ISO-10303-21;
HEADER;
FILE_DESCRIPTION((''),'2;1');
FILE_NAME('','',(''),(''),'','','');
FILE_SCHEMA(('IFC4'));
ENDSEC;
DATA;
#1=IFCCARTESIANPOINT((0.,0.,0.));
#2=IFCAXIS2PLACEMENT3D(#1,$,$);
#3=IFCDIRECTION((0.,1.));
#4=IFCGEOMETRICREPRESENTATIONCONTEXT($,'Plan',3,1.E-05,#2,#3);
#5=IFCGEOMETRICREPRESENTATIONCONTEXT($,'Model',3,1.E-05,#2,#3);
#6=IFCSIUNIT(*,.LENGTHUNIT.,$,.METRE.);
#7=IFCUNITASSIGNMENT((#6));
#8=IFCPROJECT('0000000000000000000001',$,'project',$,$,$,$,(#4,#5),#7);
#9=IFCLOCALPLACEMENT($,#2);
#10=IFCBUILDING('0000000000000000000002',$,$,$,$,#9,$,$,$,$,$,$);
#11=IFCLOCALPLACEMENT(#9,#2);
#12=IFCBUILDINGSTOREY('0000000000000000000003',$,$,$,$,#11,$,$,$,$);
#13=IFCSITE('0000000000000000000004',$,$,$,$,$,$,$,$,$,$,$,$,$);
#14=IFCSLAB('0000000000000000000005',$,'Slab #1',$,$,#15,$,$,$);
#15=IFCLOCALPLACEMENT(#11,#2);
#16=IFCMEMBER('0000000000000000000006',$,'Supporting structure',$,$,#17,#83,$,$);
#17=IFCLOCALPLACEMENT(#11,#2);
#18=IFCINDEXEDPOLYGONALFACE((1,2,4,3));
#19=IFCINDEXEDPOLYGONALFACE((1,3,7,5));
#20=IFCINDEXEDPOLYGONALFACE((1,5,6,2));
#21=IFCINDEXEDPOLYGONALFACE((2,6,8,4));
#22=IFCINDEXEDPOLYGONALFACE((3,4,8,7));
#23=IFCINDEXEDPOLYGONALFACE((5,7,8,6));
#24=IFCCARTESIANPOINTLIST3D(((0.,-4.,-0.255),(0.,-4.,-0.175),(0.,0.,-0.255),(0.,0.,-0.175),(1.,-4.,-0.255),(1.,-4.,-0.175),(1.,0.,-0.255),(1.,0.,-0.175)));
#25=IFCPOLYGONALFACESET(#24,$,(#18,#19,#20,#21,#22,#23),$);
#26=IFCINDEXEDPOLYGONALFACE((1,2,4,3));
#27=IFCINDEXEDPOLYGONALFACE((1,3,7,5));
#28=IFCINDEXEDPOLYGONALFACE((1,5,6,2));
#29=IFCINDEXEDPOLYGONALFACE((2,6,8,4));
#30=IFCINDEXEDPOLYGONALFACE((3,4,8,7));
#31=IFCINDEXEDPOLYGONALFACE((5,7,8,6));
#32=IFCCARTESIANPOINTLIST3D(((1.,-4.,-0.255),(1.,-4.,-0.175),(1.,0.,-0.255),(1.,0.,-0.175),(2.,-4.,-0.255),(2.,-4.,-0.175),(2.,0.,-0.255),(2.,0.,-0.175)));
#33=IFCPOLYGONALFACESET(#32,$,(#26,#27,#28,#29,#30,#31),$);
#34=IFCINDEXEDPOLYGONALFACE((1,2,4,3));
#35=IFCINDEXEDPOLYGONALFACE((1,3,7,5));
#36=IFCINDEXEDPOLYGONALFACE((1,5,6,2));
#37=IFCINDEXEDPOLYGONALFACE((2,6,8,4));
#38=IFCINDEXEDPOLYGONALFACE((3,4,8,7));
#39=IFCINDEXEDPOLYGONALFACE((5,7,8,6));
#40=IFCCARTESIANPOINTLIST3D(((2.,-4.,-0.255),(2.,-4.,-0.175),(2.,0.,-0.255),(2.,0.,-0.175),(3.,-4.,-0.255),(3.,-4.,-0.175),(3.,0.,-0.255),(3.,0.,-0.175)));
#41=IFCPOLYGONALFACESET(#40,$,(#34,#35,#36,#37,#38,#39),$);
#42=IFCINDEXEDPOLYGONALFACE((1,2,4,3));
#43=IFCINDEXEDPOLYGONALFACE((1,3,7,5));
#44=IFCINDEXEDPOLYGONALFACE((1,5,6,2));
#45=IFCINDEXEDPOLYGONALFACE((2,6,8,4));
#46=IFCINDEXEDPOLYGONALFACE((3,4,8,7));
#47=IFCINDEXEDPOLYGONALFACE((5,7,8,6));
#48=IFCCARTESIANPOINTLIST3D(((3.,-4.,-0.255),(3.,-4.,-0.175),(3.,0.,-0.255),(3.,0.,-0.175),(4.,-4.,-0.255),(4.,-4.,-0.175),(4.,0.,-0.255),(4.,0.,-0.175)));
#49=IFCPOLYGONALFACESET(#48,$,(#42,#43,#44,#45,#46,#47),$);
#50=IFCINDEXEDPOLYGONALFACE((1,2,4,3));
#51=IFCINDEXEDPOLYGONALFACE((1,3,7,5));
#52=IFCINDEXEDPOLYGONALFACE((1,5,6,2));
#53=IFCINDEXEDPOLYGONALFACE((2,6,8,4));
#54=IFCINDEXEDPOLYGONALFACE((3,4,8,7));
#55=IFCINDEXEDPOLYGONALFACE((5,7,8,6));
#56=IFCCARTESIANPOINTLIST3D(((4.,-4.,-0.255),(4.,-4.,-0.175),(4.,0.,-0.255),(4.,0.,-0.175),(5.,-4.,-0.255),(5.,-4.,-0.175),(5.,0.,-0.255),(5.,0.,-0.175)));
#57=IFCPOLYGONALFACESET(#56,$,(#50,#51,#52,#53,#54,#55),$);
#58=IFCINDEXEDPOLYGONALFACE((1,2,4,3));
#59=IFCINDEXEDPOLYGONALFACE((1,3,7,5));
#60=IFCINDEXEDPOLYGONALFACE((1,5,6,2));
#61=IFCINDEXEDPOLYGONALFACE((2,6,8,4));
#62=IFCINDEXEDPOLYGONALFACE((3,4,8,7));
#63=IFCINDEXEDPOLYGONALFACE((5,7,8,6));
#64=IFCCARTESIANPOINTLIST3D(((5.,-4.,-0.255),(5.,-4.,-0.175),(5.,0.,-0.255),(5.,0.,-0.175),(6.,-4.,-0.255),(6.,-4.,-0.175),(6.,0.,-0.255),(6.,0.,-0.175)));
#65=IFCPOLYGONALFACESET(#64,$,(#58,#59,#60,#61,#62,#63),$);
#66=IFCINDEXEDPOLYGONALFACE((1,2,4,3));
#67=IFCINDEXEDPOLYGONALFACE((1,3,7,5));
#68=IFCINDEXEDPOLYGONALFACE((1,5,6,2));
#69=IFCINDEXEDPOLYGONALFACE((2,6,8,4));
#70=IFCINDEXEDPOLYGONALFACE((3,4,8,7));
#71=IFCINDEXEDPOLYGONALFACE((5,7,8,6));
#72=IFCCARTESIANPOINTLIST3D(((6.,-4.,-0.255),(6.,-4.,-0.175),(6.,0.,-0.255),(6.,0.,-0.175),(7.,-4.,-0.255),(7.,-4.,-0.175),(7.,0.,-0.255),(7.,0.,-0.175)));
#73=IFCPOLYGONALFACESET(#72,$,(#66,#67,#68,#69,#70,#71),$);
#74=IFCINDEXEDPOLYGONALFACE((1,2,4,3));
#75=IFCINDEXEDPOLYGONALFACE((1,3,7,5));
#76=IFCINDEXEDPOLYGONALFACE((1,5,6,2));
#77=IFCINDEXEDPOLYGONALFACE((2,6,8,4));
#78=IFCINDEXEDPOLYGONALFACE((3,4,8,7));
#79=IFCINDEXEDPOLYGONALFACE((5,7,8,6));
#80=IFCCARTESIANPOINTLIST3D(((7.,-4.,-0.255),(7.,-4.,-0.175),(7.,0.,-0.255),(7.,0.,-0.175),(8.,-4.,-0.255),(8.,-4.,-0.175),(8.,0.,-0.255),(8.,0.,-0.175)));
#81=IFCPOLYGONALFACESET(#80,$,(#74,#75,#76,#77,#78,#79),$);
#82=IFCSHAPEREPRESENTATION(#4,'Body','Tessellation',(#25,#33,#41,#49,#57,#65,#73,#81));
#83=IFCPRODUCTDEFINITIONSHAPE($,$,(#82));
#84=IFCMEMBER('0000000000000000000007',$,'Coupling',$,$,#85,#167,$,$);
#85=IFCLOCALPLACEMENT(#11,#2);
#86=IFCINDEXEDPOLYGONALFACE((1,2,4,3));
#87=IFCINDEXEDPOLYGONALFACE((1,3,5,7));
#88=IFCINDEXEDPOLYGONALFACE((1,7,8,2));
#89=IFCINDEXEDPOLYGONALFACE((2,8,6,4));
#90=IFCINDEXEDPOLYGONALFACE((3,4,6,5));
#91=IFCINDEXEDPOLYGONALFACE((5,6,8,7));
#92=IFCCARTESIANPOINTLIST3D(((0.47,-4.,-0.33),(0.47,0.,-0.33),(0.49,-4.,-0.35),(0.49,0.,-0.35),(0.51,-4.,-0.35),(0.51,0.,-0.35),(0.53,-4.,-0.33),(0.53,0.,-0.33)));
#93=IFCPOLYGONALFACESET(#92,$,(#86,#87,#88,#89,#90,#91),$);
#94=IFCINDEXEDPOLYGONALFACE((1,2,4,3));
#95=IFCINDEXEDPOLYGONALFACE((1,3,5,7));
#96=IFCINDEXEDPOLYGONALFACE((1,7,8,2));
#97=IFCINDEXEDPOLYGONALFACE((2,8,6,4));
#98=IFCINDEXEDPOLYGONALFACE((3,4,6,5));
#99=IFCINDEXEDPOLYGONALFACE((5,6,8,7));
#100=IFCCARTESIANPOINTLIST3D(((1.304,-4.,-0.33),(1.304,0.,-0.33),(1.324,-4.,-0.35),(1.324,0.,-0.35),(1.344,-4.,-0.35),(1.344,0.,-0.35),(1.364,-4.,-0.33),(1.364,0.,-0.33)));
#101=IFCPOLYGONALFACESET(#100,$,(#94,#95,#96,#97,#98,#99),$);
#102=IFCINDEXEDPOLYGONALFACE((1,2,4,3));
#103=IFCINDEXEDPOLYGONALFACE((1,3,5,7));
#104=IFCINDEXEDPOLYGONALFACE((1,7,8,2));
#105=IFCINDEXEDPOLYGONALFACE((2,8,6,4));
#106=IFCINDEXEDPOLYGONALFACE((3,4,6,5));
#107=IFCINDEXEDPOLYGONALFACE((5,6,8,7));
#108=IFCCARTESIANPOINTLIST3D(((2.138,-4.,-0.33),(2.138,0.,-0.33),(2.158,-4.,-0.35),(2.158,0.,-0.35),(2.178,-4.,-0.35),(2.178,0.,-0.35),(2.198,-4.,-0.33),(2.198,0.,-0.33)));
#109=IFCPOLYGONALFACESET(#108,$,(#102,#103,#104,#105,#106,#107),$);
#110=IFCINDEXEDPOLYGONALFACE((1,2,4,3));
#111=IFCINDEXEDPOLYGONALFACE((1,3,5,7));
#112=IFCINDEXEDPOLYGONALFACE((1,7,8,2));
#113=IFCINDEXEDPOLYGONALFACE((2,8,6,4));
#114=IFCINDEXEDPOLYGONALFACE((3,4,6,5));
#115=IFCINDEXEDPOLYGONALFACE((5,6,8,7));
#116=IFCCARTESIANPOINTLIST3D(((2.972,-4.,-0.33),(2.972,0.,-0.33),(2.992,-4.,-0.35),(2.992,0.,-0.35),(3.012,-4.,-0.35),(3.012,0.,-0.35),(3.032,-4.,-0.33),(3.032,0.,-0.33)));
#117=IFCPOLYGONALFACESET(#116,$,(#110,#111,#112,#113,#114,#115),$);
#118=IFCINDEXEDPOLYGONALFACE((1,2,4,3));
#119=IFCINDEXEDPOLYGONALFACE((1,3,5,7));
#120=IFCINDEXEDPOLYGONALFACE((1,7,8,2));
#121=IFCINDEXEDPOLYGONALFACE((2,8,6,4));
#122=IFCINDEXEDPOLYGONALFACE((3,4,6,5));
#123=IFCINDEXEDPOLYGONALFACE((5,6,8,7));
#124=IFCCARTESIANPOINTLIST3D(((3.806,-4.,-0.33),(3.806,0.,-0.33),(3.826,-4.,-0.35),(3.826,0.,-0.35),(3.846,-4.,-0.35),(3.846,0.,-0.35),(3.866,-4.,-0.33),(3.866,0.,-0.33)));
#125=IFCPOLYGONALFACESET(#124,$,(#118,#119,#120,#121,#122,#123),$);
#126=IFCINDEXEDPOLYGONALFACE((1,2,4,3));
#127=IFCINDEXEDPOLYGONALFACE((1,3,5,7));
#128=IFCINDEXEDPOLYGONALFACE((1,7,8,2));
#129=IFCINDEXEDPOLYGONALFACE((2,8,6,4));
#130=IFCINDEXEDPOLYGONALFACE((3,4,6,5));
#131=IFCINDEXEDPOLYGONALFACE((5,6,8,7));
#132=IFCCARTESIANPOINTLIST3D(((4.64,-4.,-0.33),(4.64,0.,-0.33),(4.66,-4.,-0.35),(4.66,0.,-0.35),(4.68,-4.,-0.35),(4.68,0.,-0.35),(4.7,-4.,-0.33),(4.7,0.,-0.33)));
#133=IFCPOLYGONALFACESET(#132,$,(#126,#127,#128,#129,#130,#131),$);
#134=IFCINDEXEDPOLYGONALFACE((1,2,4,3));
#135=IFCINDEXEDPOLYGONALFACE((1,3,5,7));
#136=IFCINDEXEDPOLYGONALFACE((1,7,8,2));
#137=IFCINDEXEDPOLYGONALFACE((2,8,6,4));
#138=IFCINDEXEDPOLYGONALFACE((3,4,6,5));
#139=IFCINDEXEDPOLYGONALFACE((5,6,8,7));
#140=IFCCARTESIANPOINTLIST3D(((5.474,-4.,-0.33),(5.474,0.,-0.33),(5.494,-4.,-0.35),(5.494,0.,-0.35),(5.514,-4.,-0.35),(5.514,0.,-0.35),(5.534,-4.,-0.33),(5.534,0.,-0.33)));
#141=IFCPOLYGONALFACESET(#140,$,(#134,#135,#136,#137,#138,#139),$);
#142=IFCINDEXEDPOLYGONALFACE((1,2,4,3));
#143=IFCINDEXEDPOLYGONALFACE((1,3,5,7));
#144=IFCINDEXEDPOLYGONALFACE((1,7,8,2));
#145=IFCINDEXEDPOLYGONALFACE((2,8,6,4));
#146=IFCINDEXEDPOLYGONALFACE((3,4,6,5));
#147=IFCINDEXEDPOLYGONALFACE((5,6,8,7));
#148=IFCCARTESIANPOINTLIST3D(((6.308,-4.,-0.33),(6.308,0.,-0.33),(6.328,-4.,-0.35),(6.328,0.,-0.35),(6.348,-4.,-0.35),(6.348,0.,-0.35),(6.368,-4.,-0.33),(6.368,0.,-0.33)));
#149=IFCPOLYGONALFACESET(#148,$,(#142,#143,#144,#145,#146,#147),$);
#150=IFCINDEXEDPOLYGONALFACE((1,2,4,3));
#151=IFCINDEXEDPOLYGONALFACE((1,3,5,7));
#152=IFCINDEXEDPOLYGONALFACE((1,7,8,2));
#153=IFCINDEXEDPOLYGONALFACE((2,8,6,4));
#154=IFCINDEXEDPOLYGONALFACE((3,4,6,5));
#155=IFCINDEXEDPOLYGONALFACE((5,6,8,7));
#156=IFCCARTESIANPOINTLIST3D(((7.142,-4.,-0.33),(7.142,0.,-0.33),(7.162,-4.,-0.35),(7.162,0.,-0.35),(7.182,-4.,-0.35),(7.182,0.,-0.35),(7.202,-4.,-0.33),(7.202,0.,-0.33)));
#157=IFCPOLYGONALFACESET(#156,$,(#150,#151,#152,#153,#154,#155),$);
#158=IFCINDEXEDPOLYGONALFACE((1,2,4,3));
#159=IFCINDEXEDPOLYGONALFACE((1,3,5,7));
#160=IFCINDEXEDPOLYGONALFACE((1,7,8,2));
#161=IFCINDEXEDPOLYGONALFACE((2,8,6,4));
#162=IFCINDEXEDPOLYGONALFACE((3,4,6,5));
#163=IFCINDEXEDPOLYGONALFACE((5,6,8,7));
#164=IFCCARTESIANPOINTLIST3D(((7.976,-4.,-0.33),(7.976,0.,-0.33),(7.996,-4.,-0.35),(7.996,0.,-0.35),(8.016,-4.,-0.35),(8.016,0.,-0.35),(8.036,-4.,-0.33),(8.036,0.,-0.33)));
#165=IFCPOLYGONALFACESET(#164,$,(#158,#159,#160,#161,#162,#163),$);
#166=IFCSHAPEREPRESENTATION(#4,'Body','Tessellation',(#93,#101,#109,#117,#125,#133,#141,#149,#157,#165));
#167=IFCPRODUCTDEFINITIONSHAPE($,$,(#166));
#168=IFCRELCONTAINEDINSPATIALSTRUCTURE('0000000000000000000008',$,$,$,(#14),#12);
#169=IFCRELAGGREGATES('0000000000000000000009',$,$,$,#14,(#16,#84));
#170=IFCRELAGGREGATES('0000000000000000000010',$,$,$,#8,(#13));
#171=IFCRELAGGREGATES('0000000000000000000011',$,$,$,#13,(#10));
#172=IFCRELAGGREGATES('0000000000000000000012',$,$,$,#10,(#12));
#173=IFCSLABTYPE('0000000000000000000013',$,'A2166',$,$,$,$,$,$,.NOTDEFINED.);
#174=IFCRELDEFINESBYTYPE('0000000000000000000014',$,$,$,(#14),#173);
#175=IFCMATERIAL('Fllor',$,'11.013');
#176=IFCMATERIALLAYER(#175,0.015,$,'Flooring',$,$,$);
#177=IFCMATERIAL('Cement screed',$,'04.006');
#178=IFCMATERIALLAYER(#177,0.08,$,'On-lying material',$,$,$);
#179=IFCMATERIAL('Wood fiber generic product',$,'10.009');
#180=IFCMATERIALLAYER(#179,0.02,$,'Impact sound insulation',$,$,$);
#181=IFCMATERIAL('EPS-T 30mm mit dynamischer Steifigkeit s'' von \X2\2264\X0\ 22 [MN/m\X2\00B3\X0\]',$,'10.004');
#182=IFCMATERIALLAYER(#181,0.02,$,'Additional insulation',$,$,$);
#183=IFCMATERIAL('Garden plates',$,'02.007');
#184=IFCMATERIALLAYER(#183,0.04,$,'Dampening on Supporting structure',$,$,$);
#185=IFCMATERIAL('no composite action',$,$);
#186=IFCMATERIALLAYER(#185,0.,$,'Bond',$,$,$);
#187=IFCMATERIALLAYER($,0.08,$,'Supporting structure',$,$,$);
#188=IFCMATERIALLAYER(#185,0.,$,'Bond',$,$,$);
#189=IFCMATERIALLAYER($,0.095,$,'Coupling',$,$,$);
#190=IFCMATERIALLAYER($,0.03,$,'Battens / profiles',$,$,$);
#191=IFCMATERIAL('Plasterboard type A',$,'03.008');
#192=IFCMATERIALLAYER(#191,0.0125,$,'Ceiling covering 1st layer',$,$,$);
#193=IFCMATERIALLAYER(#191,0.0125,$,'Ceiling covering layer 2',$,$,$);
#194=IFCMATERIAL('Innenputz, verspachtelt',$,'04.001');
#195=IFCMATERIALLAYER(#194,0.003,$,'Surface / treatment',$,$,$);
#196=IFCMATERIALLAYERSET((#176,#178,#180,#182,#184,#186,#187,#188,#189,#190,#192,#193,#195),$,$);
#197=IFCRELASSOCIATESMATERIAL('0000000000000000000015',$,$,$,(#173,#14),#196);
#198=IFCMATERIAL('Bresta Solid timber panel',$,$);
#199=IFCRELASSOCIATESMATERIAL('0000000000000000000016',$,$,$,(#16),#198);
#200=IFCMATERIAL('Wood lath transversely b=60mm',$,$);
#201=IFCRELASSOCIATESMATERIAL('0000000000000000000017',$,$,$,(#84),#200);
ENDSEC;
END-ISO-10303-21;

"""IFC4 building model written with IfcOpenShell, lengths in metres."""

from ifc_helpers import new_model, si_unit, direction, frame, frame_2d, origin, place, context, project, spatial, polyline, rectangle, outline, extrude, material, layer, layer_set, type_object, element, aggregate, save


model = new_model("IFC4")

# Units and contexts
plan_context = context("Plan", 3, precision=1e-05, world=origin(), true_north=direction((0.0, 1.0)))
model_context = context("Model", 3, precision=1e-05, world=origin(), true_north=direction((0.0, 1.0)))
ifc_project = project(units=[si_unit("LENGTHUNIT", "METRE")], contexts=[plan_context, model_context])

# Site, building, storey
site = spatial("IfcSite", under=ifc_project)
building_placement = place(None, origin())
building = spatial("IfcBuilding", under=site, at=building_placement)
storey_placement = place(building_placement, origin())
storey = spatial("IfcBuildingStorey", under=building, at=storey_placement)

# Slab, members
ifc_material_1 = material(Name="Fllor", Category="11.013")
ifc_layer_1 = layer(ifc_material_1, 0.015, Name="Flooring")
ifc_material_2 = material(Name="Cement screed", Category="04.006")
ifc_layer_2 = layer(ifc_material_2, 0.08, Name="On-lying material")
ifc_material_3 = material(Name="Wood fiber generic product", Category="10.009")
ifc_layer_3 = layer(ifc_material_3, 0.02, Name="Impact sound insulation")
ifc_material_4 = material(Name="EPS-T 30mm mit dynamischer Steifigkeit s' von ≤ 22 [MN/m³]", Category="10.004")
ifc_layer_4 = layer(ifc_material_4, 0.02, Name="Additional insulation")
ifc_material_5 = material(Name="Garden plates", Category="02.007")
ifc_layer_5 = layer(ifc_material_5, 0.04, Name="Dampening on Supporting structure")
ifc_material_6 = material(Name="no composite action")
ifc_layer_6 = layer(ifc_material_6, 0.0, Name="Bond")
ifc_layer_7 = layer(None, 0.08, Name="Supporting structure")
ifc_layer_8 = layer(ifc_material_6, 0.0, Name="Bond")
ifc_layer_9 = layer(None, 0.095, Name="Coupling")
ifc_layer_10 = layer(None, 0.03, Name="Battens / profiles")
ifc_material_7 = material(Name="Plasterboard type A", Category="03.008")
ifc_layer_11 = layer(ifc_material_7, 0.0125, Name="Ceiling covering 1st layer")
ifc_layer_12 = layer(ifc_material_7, 0.0125, Name="Ceiling covering layer 2")
ifc_material_8 = material(Name="Innenputz, verspachtelt", Category="04.001")
ifc_layer_13 = layer(ifc_material_8, 0.003, Name="Surface / treatment")
ifc_layer_set = layer_set([ifc_layer_1, ifc_layer_2, ifc_layer_3, ifc_layer_4, ifc_layer_5, ifc_layer_6, ifc_layer_7, ifc_layer_8, ifc_layer_9, ifc_layer_10, ifc_layer_11, ifc_layer_12, ifc_layer_13])
slab_type = type_object("IfcSlabType", Name="A2166", PredefinedType="NOTDEFINED", material=ifc_layer_set)
slab_placement = place(None, frame((0.0, 0.0, 0.0), z_axis=(0.0, 0.0, -1.0), x_axis=(1.0, 0.0, 0.0)))
slab = element("IfcSlab", 1, at=slab_placement, inside=storey, type_object=slab_type, material=ifc_layer_set, Name="Slab #1")
ifc_material_9 = material(Name="Bresta Solid timber panel")
member_1_placement = place(slab_placement, origin())
member_1 = element("IfcMember", 2, at=member_1_placement, material=ifc_material_9, Name="Supporting structure", context=plan_context, shape_type="SweptSolid", body=[
    extrude(rectangle(XDim=1.0, YDim=0.08, at=frame_2d((0.5, 0.04), x_axis=(1.0, 0.0))), frame((0.0, 4.0, 0.175), z_axis=(0.0, -1.0, 0.0), x_axis=(1.0, 0.0, 0.0)), (0.0, 0.0, 1.0), 4.0),
    extrude(rectangle(XDim=1.0, YDim=0.08, at=frame_2d((0.5, 0.04), x_axis=(1.0, 0.0))), frame((1.0, 4.0, 0.175), z_axis=(0.0, -1.0, 0.0), x_axis=(1.0, 0.0, 0.0)), (0.0, 0.0, 1.0), 4.0),
    extrude(rectangle(XDim=1.0, YDim=0.08, at=frame_2d((0.5, 0.04), x_axis=(1.0, 0.0))), frame((2.0, 4.0, 0.175), z_axis=(0.0, -1.0, 0.0), x_axis=(1.0, 0.0, 0.0)), (0.0, 0.0, 1.0), 4.0),
    extrude(rectangle(XDim=1.0, YDim=0.08, at=frame_2d((0.5, 0.04), x_axis=(1.0, 0.0))), frame((3.0, 4.0, 0.175), z_axis=(0.0, -1.0, 0.0), x_axis=(1.0, 0.0, 0.0)), (0.0, 0.0, 1.0), 4.0),
    extrude(rectangle(XDim=1.0, YDim=0.08, at=frame_2d((0.5, 0.04), x_axis=(1.0, 0.0))), frame((4.0, 4.0, 0.175), z_axis=(0.0, -1.0, 0.0), x_axis=(1.0, 0.0, 0.0)), (0.0, 0.0, 1.0), 4.0),
    extrude(rectangle(XDim=1.0, YDim=0.08, at=frame_2d((0.5, 0.04), x_axis=(1.0, 0.0))), frame((5.0, 4.0, 0.175), z_axis=(0.0, -1.0, 0.0), x_axis=(1.0, 0.0, 0.0)), (0.0, 0.0, 1.0), 4.0),
    extrude(rectangle(XDim=1.0, YDim=0.08, at=frame_2d((0.5, 0.04), x_axis=(1.0, 0.0))), frame((6.0, 4.0, 0.175), z_axis=(0.0, -1.0, 0.0), x_axis=(1.0, 0.0, 0.0)), (0.0, 0.0, 1.0), 4.0),
    extrude(rectangle(XDim=1.0, YDim=0.08, at=frame_2d((0.5, 0.04), x_axis=(1.0, 0.0))), frame((7.0, 4.0, 0.175), z_axis=(0.0, -1.0, 0.0), x_axis=(1.0, 0.0, 0.0)), (0.0, 0.0, 1.0), 4.0),
])
ifc_material_10 = material(Name="Wood lath transversely b=60mm")
member_2_placement = place(slab_placement, origin())
member_2 = element("IfcMember", 3, at=member_2_placement, material=ifc_material_10, Name="Coupling", context=plan_context, shape_type="SweptSolid", body=[
    extrude(outline(polyline([(0.0, 0.0), (0.06, 0.0), (0.04, 0.02), (0.02, 0.02), (0.0, 0.0)])), frame((0.47, 4.0, 0.33), z_axis=(0.0, -1.0, 0.0), x_axis=(1.0, 0.0, 0.0)), (0.0, 0.0, 1.0), 4.0),
    extrude(outline(polyline([(0.0, 0.0), (0.06, 0.0), (0.04, 0.02), (0.02, 0.02), (0.0, 0.0)])), frame((1.304, 4.0, 0.33), z_axis=(0.0, -1.0, 0.0), x_axis=(1.0, 0.0, 0.0)), (0.0, 0.0, 1.0), 4.0),
    extrude(outline(polyline([(0.0, 0.0), (0.06, 0.0), (0.04, 0.02), (0.02, 0.02), (0.0, 0.0)])), frame((2.138, 4.0, 0.33), z_axis=(0.0, -1.0, 0.0), x_axis=(1.0, 0.0, 0.0)), (0.0, 0.0, 1.0), 4.0),
    extrude(outline(polyline([(0.0, 0.0), (0.06, 0.0), (0.04, 0.02), (0.02, 0.02), (0.0, 0.0)])), frame((2.972, 4.0, 0.33), z_axis=(0.0, -1.0, 0.0), x_axis=(1.0, 0.0, 0.0)), (0.0, 0.0, 1.0), 4.0),
    extrude(outline(polyline([(0.0, 0.0), (0.06, 0.0), (0.04, 0.02), (0.02, 0.02), (0.0, 0.0)])), frame((3.806, 4.0, 0.33), z_axis=(0.0, -1.0, 0.0), x_axis=(1.0, 0.0, 0.0)), (0.0, 0.0, 1.0), 4.0),
    extrude(outline(polyline([(0.0, 0.0), (0.06, 0.0), (0.04, 0.02), (0.02, 0.02), (0.0, 0.0)])), frame((4.64, 4.0, 0.33), z_axis=(0.0, -1.0, 0.0), x_axis=(1.0, 0.0, 0.0)), (0.0, 0.0, 1.0), 4.0),
    extrude(outline(polyline([(0.0, 0.0), (0.06, 0.0), (0.04, 0.02), (0.02, 0.02), (0.0, 0.0)])), frame((5.474, 4.0, 0.33), z_axis=(0.0, -1.0, 0.0), x_axis=(1.0, 0.0, 0.0)), (0.0, 0.0, 1.0), 4.0),
    extrude(outline(polyline([(0.0, 0.0), (0.06, 0.0), (0.04, 0.02), (0.02, 0.02), (0.0, 0.0)])), frame((6.308, 4.0, 0.33), z_axis=(0.0, -1.0, 0.0), x_axis=(1.0, 0.0, 0.0)), (0.0, 0.0, 1.0), 4.0),
    extrude(outline(polyline([(0.0, 0.0), (0.06, 0.0), (0.04, 0.02), (0.02, 0.02), (0.0, 0.0)])), frame((7.142, 4.0, 0.33), z_axis=(0.0, -1.0, 0.0), x_axis=(1.0, 0.0, 0.0)), (0.0, 0.0, 1.0), 4.0),
    extrude(outline(polyline([(0.0, 0.0), (0.06, 0.0), (0.04, 0.02), (0.02, 0.02), (0.0, 0.0)])), frame((7.976, 4.0, 0.33), z_axis=(0.0, -1.0, 0.0), x_axis=(1.0, 0.0, 0.0)), (0.0, 0.0, 1.0), 4.0),
])
aggregate(slab, [member_1, member_2])

save(model, "model.ifc")
